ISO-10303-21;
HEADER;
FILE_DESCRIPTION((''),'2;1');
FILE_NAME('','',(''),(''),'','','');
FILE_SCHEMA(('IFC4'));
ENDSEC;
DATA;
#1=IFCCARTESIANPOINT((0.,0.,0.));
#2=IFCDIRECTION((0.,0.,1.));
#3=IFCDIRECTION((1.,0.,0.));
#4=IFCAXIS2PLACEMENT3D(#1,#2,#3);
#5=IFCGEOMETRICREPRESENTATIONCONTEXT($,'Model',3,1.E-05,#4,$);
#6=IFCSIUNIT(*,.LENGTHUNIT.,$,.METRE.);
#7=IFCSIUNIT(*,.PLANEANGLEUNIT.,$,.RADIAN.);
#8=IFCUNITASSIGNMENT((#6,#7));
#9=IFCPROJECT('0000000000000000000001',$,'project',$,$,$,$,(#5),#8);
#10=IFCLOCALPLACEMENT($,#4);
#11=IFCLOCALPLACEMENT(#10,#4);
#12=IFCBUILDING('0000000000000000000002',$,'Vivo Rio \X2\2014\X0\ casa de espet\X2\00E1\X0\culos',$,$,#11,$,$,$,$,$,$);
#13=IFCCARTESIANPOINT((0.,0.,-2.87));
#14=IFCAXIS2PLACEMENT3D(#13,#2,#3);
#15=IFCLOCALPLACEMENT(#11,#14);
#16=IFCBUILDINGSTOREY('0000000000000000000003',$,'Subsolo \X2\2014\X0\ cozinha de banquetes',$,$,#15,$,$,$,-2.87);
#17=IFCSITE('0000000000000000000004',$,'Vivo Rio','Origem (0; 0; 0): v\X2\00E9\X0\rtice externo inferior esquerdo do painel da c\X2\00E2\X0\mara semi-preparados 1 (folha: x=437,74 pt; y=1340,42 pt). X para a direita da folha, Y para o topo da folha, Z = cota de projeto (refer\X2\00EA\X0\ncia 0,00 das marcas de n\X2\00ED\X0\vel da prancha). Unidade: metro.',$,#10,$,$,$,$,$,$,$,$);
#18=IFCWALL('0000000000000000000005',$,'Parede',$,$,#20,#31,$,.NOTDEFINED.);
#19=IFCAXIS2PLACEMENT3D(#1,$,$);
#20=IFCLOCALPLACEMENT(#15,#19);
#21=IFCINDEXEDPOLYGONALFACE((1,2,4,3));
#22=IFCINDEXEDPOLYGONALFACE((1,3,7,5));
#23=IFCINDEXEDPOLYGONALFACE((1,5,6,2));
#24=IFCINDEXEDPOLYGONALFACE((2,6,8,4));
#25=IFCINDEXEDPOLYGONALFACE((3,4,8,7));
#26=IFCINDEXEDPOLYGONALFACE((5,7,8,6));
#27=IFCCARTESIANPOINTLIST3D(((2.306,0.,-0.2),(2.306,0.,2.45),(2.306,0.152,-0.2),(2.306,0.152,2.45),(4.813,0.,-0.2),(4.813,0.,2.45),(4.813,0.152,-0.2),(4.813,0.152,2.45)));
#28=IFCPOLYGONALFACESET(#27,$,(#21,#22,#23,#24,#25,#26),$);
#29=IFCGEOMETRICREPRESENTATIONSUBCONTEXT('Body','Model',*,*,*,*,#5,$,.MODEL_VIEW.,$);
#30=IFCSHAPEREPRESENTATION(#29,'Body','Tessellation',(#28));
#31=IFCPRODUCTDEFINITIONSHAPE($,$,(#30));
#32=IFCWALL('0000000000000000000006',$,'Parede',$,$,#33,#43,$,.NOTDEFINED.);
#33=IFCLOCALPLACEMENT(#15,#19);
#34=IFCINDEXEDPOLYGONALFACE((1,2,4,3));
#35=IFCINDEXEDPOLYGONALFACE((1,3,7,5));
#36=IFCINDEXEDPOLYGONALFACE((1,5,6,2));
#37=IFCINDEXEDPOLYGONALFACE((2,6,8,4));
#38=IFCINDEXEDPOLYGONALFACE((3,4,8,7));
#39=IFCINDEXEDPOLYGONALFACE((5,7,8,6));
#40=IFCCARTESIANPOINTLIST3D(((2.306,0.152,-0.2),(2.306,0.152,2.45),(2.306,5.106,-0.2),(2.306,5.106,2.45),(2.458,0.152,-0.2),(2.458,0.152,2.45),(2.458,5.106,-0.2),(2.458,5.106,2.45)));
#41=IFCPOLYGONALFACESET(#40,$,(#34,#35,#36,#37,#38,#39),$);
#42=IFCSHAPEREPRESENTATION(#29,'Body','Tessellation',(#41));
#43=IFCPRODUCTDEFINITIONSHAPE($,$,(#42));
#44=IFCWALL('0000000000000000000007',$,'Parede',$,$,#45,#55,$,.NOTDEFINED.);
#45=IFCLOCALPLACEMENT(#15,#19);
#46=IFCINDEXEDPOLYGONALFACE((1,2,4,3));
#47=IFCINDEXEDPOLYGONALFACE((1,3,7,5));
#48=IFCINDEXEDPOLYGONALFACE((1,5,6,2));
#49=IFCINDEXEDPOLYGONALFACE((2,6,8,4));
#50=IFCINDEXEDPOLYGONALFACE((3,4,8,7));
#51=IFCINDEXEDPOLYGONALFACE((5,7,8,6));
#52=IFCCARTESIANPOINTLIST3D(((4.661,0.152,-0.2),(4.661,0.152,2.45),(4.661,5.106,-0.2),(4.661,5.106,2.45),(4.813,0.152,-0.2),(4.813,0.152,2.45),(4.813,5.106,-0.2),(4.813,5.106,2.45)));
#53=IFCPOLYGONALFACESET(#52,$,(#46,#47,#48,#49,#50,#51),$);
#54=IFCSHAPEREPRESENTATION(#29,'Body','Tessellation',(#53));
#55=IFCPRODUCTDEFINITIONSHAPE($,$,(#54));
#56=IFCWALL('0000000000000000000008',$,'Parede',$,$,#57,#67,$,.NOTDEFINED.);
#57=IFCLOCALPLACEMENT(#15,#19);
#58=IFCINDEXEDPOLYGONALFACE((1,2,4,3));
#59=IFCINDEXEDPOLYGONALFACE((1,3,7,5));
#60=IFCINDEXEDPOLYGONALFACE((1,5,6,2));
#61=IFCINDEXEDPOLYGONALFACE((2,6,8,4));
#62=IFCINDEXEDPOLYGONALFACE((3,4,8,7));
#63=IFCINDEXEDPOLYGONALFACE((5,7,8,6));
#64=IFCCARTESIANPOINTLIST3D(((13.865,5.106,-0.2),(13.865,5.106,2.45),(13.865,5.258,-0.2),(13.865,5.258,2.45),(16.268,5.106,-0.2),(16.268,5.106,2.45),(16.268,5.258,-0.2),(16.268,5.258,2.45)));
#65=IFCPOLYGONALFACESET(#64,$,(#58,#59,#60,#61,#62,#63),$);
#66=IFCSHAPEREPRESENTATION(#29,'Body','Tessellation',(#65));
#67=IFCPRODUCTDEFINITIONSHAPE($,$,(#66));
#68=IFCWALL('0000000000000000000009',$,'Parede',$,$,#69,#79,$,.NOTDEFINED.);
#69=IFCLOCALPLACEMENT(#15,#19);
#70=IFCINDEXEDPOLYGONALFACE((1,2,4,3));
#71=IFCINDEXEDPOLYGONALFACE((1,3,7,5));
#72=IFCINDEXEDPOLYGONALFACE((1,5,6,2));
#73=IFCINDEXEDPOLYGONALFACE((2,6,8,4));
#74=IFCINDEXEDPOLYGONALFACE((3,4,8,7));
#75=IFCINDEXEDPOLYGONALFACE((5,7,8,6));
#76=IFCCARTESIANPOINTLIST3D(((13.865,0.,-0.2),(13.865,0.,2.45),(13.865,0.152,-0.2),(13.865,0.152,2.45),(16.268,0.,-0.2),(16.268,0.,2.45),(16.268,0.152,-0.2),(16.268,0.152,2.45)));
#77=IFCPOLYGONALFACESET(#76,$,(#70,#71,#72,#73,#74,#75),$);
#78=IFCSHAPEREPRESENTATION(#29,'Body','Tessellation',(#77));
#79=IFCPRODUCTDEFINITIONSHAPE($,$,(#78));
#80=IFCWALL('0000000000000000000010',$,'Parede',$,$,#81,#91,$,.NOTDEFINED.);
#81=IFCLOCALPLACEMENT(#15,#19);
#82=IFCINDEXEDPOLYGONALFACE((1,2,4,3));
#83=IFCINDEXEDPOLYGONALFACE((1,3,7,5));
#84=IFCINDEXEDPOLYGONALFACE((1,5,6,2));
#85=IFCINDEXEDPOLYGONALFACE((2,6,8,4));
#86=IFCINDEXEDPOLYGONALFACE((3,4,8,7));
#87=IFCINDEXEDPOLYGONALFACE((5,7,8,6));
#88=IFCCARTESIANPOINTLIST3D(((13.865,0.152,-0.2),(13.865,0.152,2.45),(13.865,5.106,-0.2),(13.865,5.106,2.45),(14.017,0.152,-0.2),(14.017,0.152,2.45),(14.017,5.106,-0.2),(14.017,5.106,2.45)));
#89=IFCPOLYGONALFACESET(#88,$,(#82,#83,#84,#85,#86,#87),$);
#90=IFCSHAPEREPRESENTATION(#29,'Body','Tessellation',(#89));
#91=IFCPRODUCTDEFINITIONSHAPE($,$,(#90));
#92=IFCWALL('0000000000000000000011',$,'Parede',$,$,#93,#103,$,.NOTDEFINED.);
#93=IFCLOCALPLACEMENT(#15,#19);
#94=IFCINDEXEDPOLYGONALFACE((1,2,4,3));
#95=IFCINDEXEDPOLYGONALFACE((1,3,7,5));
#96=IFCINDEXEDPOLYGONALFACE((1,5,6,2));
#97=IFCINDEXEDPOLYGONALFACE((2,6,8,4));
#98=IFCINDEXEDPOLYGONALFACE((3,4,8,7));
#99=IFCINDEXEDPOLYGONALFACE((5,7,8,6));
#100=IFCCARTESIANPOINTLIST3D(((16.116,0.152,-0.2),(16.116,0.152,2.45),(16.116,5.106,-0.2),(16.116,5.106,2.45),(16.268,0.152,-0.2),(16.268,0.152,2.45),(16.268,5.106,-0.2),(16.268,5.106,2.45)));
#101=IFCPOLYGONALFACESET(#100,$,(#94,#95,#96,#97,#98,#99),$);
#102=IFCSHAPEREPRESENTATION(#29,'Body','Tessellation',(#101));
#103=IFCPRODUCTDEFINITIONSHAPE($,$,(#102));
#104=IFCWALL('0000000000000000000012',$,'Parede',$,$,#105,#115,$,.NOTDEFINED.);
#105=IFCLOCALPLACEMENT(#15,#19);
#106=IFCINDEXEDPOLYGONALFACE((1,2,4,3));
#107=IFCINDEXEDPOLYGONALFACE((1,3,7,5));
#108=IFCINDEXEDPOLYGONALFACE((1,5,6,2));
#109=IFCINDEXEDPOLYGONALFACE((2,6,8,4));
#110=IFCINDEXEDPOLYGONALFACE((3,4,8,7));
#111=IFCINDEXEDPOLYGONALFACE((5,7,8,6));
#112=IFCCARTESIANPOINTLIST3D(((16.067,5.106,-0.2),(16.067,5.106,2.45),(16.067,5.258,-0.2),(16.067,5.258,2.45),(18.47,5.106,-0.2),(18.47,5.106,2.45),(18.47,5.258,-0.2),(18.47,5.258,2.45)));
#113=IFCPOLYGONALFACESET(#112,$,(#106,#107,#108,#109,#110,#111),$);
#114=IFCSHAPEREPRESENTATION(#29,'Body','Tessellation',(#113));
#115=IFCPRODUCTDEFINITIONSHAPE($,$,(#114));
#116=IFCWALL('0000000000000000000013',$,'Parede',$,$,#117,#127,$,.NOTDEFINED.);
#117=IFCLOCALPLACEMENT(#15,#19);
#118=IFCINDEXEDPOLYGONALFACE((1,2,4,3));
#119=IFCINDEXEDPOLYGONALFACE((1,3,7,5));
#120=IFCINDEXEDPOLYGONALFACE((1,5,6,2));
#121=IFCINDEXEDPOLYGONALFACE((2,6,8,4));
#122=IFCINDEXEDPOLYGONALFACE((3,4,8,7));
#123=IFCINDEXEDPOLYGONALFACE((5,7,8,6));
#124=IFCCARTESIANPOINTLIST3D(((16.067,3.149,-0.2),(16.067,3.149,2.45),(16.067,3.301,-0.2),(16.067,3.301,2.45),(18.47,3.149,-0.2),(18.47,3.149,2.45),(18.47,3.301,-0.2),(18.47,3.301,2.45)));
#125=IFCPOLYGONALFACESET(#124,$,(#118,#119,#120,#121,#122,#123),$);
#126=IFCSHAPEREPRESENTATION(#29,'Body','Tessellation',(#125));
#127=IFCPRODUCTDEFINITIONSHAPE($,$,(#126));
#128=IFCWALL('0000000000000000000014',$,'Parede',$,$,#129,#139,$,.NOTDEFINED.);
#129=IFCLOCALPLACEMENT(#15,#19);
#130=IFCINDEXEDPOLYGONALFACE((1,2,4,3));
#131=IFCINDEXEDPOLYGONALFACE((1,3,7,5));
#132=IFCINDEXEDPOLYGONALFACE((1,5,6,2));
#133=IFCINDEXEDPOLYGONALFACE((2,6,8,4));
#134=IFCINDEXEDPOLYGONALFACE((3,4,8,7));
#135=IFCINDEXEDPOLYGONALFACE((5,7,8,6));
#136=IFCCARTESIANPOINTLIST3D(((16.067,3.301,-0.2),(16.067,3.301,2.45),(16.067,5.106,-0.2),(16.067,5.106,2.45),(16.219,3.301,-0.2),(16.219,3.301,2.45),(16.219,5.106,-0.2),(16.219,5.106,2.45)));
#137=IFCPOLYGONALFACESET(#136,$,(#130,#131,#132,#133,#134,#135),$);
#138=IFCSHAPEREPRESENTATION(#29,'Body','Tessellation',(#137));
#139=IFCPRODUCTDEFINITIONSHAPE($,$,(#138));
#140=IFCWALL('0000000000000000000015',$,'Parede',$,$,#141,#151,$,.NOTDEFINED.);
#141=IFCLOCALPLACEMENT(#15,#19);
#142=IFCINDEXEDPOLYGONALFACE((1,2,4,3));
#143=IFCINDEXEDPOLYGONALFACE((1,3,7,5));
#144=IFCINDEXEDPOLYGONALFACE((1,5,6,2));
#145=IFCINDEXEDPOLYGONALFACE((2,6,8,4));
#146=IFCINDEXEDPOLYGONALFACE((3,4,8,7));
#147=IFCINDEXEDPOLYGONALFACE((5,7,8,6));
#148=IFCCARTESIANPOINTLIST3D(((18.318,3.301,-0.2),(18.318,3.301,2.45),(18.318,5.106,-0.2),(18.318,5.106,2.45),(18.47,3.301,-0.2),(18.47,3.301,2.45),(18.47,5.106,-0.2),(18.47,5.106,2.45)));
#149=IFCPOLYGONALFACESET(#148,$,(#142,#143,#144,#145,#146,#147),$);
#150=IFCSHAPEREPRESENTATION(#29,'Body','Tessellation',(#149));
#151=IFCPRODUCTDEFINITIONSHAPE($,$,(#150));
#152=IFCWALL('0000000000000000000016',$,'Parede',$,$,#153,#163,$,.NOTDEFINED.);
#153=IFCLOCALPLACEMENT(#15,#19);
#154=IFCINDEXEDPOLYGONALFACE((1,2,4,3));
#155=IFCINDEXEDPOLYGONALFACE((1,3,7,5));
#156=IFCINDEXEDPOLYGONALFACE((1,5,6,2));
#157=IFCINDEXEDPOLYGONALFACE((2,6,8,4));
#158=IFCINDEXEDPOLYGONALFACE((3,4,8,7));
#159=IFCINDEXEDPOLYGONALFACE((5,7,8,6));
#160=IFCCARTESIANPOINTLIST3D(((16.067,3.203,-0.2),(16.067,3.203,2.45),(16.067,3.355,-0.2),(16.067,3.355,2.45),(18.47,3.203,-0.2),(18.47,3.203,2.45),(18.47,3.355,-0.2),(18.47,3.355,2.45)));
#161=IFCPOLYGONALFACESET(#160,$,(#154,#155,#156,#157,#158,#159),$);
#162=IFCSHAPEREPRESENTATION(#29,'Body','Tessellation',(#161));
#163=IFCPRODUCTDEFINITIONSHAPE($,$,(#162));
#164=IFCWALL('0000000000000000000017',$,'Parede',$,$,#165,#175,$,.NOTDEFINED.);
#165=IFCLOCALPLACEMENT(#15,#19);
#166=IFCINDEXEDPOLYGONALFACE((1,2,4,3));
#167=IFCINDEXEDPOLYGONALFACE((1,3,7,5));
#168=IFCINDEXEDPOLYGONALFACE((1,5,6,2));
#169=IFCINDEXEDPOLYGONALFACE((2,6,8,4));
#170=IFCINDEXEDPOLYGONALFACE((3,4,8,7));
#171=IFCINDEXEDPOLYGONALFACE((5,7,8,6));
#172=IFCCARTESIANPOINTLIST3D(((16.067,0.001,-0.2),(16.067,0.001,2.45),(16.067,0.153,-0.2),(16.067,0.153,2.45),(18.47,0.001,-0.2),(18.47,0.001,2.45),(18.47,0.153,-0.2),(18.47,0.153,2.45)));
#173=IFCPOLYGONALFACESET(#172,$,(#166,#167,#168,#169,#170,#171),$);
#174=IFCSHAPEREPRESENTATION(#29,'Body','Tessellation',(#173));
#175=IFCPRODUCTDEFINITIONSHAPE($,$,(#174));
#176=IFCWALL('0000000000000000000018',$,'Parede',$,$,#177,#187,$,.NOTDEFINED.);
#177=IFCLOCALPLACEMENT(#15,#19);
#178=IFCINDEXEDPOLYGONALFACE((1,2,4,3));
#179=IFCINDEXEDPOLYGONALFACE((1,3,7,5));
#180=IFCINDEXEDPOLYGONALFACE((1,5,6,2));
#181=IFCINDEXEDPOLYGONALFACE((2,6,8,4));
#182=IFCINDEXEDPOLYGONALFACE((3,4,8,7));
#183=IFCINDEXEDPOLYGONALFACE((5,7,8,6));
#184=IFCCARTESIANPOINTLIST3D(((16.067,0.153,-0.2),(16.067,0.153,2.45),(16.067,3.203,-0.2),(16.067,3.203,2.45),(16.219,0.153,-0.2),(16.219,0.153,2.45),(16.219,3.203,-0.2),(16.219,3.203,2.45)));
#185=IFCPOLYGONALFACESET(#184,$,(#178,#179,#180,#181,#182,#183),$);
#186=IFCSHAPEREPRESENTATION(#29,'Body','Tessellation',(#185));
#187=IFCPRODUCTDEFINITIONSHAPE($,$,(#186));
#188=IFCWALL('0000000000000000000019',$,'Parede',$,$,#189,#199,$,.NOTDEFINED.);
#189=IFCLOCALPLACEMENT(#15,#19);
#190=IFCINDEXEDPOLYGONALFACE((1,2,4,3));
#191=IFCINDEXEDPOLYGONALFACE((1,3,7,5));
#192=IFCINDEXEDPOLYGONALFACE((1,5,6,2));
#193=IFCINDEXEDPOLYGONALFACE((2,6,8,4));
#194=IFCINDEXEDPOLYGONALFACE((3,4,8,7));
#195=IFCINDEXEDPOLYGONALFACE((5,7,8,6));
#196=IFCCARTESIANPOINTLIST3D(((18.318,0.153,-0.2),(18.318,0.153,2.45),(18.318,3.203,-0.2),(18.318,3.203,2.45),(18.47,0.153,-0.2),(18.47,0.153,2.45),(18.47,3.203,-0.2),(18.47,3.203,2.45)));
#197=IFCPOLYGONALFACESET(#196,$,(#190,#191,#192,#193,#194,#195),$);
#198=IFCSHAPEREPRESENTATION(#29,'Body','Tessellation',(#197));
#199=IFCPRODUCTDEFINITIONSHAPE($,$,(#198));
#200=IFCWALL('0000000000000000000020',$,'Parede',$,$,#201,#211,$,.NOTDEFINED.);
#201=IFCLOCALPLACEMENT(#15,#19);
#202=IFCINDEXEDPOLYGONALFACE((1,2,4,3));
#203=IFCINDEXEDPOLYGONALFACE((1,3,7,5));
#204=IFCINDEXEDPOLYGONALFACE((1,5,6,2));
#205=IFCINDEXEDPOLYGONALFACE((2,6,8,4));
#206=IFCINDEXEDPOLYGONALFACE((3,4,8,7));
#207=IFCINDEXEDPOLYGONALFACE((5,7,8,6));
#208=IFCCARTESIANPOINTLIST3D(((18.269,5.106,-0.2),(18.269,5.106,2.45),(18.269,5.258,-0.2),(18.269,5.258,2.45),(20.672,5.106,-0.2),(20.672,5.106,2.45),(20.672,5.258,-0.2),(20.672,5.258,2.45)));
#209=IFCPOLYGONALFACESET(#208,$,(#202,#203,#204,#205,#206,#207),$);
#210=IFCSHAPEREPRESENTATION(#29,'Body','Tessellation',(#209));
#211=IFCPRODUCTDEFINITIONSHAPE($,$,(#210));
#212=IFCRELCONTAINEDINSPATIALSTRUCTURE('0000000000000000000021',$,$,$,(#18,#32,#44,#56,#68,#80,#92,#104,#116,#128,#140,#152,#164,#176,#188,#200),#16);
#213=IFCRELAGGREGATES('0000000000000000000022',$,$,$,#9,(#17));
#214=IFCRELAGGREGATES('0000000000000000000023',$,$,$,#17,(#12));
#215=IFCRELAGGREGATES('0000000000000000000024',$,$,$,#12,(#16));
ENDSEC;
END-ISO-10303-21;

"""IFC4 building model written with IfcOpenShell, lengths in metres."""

from ifc_helpers import new_model, si_unit, frame, origin_with_axes, origin_2d, place, context, subcontext, project, spatial, rectangle, extrude, element, save


model = new_model("IFC4")

# Units and contexts
model_context = context("Model", 3, precision=1e-05, world=origin_with_axes())
body_context = subcontext(model_context, "Body", "Model", "MODEL_VIEW")
ifc_project = project(units=[si_unit("LENGTHUNIT", "METRE"), si_unit("PLANEANGLEUNIT", "RADIAN")], contexts=[model_context])

# Site, building, storey
site_placement = place(None, origin_with_axes())
site = spatial("IfcSite", under=ifc_project, at=site_placement, Name="Vivo Rio", Description="Origem (0; 0; 0): vértice externo inferior esquerdo do painel da câmara semi-preparados 1 (folha: x=437,74 pt; y=1340,42 pt). X para a direita da folha, Y para o topo da folha, Z = cota de projeto (referência 0,00 das marcas de nível da prancha). Unidade: metro.")
building_placement = place(site_placement, origin_with_axes())
building = spatial("IfcBuilding", under=site, at=building_placement, Name="Vivo Rio — casa de espetáculos")
storey_placement = place(building_placement, frame((0.0, 0.0, -2.87), z_axis=(0.0, 0.0, 1.0), x_axis=(1.0, 0.0, 0.0)))
storey = spatial("IfcBuildingStorey", under=building, at=storey_placement, Name="Subsolo — cozinha de banquetes", Elevation=-2.87)

# Walls
wall_1_placement = place(storey_placement, origin_with_axes())
element("IfcWall", 1, at=wall_1_placement, inside=storey, Name="Parede", PredefinedType="NOTDEFINED", context=body_context, shape_type="SweptSolid", body=[
    extrude(rectangle(XDim=2.507, YDim=0.152, at=origin_2d()), frame((3.5595, 0.076, -0.2), z_axis=(0.0, 0.0, 1.0), x_axis=(1.0, 0.0, 0.0)), (0.0, 0.0, 1.0), 2.65),
])
wall_2_placement = place(storey_placement, origin_with_axes())
element("IfcWall", 2, at=wall_2_placement, inside=storey, Name="Parede", PredefinedType="NOTDEFINED", context=body_context, shape_type="SweptSolid", body=[
    extrude(rectangle(XDim=4.954, YDim=0.152, at=origin_2d()), frame((2.382, 2.629, -0.2), z_axis=(0.0, 0.0, 1.0), x_axis=(0.0, -1.0, 0.0)), (0.0, 0.0, 1.0), 2.65),
])
wall_3_placement = place(storey_placement, origin_with_axes())
element("IfcWall", 3, at=wall_3_placement, inside=storey, Name="Parede", PredefinedType="NOTDEFINED", context=body_context, shape_type="SweptSolid", body=[
    extrude(rectangle(XDim=4.954, YDim=0.152, at=origin_2d()), frame((4.737, 2.629, -0.2), z_axis=(0.0, 0.0, 1.0), x_axis=(0.0, -1.0, 0.0)), (0.0, 0.0, 1.0), 2.65),
])
wall_4_placement = place(storey_placement, origin_with_axes())
element("IfcWall", 4, at=wall_4_placement, inside=storey, Name="Parede", PredefinedType="NOTDEFINED", context=body_context, shape_type="SweptSolid", body=[
    extrude(rectangle(XDim=2.403, YDim=0.152, at=origin_2d()), frame((15.0665, 5.182, -0.2), z_axis=(0.0, 0.0, 1.0), x_axis=(1.0, 0.0, 0.0)), (0.0, 0.0, 1.0), 2.65),
])
wall_5_placement = place(storey_placement, origin_with_axes())
element("IfcWall", 5, at=wall_5_placement, inside=storey, Name="Parede", PredefinedType="NOTDEFINED", context=body_context, shape_type="SweptSolid", body=[
    extrude(rectangle(XDim=2.403, YDim=0.152, at=origin_2d()), frame((15.0665, 0.076, -0.2), z_axis=(0.0, 0.0, 1.0), x_axis=(1.0, 0.0, 0.0)), (0.0, 0.0, 1.0), 2.65),
])
wall_6_placement = place(storey_placement, origin_with_axes())
element("IfcWall", 6, at=wall_6_placement, inside=storey, Name="Parede", PredefinedType="NOTDEFINED", context=body_context, shape_type="SweptSolid", body=[
    extrude(rectangle(XDim=4.954, YDim=0.152, at=origin_2d()), frame((13.941, 2.629, -0.2), z_axis=(0.0, 0.0, 1.0), x_axis=(0.0, -1.0, 0.0)), (0.0, 0.0, 1.0), 2.65),
])
wall_7_placement = place(storey_placement, origin_with_axes())
element("IfcWall", 7, at=wall_7_placement, inside=storey, Name="Parede", PredefinedType="NOTDEFINED", context=body_context, shape_type="SweptSolid", body=[
    extrude(rectangle(XDim=4.954, YDim=0.152, at=origin_2d()), frame((16.192, 2.629, -0.2), z_axis=(0.0, 0.0, 1.0), x_axis=(0.0, -1.0, 0.0)), (0.0, 0.0, 1.0), 2.65),
])
wall_8_placement = place(storey_placement, origin_with_axes())
element("IfcWall", 8, at=wall_8_placement, inside=storey, Name="Parede", PredefinedType="NOTDEFINED", context=body_context, shape_type="SweptSolid", body=[
    extrude(rectangle(XDim=2.403, YDim=0.152, at=origin_2d()), frame((17.2685, 5.182, -0.2), z_axis=(0.0, 0.0, 1.0), x_axis=(1.0, 0.0, 0.0)), (0.0, 0.0, 1.0), 2.65),
])
wall_9_placement = place(storey_placement, origin_with_axes())
element("IfcWall", 9, at=wall_9_placement, inside=storey, Name="Parede", PredefinedType="NOTDEFINED", context=body_context, shape_type="SweptSolid", body=[
    extrude(rectangle(XDim=2.403, YDim=0.152, at=origin_2d()), frame((17.2685, 3.225, -0.2), z_axis=(0.0, 0.0, 1.0), x_axis=(1.0, 0.0, 0.0)), (0.0, 0.0, 1.0), 2.65),
])
wall_10_placement = place(storey_placement, origin_with_axes())
element("IfcWall", 10, at=wall_10_placement, inside=storey, Name="Parede", PredefinedType="NOTDEFINED", context=body_context, shape_type="SweptSolid", body=[
    extrude(rectangle(XDim=1.805, YDim=0.152, at=origin_2d()), frame((16.143, 4.2035, -0.2), z_axis=(0.0, 0.0, 1.0), x_axis=(0.0, -1.0, 0.0)), (0.0, 0.0, 1.0), 2.65),
])
wall_11_placement = place(storey_placement, origin_with_axes())
element("IfcWall", 11, at=wall_11_placement, inside=storey, Name="Parede", PredefinedType="NOTDEFINED", context=body_context, shape_type="SweptSolid", body=[
    extrude(rectangle(XDim=1.805, YDim=0.152, at=origin_2d()), frame((18.394, 4.2035, -0.2), z_axis=(0.0, 0.0, 1.0), x_axis=(0.0, -1.0, 0.0)), (0.0, 0.0, 1.0), 2.65),
])
wall_12_placement = place(storey_placement, origin_with_axes())
element("IfcWall", 12, at=wall_12_placement, inside=storey, Name="Parede", PredefinedType="NOTDEFINED", context=body_context, shape_type="SweptSolid", body=[
    extrude(rectangle(XDim=2.403, YDim=0.152, at=origin_2d()), frame((17.2685, 3.279, -0.2), z_axis=(0.0, 0.0, 1.0), x_axis=(1.0, 0.0, 0.0)), (0.0, 0.0, 1.0), 2.65),
])
wall_13_placement = place(storey_placement, origin_with_axes())
element("IfcWall", 13, at=wall_13_placement, inside=storey, Name="Parede", PredefinedType="NOTDEFINED", context=body_context, shape_type="SweptSolid", body=[
    extrude(rectangle(XDim=2.403, YDim=0.152, at=origin_2d()), frame((17.2685, 0.077, -0.2), z_axis=(0.0, 0.0, 1.0), x_axis=(1.0, 0.0, 0.0)), (0.0, 0.0, 1.0), 2.65),
])
wall_14_placement = place(storey_placement, origin_with_axes())
element("IfcWall", 14, at=wall_14_placement, inside=storey, Name="Parede", PredefinedType="NOTDEFINED", context=body_context, shape_type="SweptSolid", body=[
    extrude(rectangle(XDim=3.05, YDim=0.152, at=origin_2d()), frame((16.143, 1.678, -0.2), z_axis=(0.0, 0.0, 1.0), x_axis=(0.0, -1.0, 0.0)), (0.0, 0.0, 1.0), 2.65),
])
wall_15_placement = place(storey_placement, origin_with_axes())
element("IfcWall", 15, at=wall_15_placement, inside=storey, Name="Parede", PredefinedType="NOTDEFINED", context=body_context, shape_type="SweptSolid", body=[
    extrude(rectangle(XDim=3.05, YDim=0.152, at=origin_2d()), frame((18.394, 1.678, -0.2), z_axis=(0.0, 0.0, 1.0), x_axis=(0.0, -1.0, 0.0)), (0.0, 0.0, 1.0), 2.65),
])
wall_16_placement = place(storey_placement, origin_with_axes())
element("IfcWall", 16, at=wall_16_placement, inside=storey, Name="Parede", PredefinedType="NOTDEFINED", context=body_context, shape_type="SweptSolid", body=[
    extrude(rectangle(XDim=2.403, YDim=0.152, at=origin_2d()), frame((19.4705, 5.182, -0.2), z_axis=(0.0, 0.0, 1.0), x_axis=(1.0, 0.0, 0.0)), (0.0, 0.0, 1.0), 2.65),
])

save(model, "model.ifc")
